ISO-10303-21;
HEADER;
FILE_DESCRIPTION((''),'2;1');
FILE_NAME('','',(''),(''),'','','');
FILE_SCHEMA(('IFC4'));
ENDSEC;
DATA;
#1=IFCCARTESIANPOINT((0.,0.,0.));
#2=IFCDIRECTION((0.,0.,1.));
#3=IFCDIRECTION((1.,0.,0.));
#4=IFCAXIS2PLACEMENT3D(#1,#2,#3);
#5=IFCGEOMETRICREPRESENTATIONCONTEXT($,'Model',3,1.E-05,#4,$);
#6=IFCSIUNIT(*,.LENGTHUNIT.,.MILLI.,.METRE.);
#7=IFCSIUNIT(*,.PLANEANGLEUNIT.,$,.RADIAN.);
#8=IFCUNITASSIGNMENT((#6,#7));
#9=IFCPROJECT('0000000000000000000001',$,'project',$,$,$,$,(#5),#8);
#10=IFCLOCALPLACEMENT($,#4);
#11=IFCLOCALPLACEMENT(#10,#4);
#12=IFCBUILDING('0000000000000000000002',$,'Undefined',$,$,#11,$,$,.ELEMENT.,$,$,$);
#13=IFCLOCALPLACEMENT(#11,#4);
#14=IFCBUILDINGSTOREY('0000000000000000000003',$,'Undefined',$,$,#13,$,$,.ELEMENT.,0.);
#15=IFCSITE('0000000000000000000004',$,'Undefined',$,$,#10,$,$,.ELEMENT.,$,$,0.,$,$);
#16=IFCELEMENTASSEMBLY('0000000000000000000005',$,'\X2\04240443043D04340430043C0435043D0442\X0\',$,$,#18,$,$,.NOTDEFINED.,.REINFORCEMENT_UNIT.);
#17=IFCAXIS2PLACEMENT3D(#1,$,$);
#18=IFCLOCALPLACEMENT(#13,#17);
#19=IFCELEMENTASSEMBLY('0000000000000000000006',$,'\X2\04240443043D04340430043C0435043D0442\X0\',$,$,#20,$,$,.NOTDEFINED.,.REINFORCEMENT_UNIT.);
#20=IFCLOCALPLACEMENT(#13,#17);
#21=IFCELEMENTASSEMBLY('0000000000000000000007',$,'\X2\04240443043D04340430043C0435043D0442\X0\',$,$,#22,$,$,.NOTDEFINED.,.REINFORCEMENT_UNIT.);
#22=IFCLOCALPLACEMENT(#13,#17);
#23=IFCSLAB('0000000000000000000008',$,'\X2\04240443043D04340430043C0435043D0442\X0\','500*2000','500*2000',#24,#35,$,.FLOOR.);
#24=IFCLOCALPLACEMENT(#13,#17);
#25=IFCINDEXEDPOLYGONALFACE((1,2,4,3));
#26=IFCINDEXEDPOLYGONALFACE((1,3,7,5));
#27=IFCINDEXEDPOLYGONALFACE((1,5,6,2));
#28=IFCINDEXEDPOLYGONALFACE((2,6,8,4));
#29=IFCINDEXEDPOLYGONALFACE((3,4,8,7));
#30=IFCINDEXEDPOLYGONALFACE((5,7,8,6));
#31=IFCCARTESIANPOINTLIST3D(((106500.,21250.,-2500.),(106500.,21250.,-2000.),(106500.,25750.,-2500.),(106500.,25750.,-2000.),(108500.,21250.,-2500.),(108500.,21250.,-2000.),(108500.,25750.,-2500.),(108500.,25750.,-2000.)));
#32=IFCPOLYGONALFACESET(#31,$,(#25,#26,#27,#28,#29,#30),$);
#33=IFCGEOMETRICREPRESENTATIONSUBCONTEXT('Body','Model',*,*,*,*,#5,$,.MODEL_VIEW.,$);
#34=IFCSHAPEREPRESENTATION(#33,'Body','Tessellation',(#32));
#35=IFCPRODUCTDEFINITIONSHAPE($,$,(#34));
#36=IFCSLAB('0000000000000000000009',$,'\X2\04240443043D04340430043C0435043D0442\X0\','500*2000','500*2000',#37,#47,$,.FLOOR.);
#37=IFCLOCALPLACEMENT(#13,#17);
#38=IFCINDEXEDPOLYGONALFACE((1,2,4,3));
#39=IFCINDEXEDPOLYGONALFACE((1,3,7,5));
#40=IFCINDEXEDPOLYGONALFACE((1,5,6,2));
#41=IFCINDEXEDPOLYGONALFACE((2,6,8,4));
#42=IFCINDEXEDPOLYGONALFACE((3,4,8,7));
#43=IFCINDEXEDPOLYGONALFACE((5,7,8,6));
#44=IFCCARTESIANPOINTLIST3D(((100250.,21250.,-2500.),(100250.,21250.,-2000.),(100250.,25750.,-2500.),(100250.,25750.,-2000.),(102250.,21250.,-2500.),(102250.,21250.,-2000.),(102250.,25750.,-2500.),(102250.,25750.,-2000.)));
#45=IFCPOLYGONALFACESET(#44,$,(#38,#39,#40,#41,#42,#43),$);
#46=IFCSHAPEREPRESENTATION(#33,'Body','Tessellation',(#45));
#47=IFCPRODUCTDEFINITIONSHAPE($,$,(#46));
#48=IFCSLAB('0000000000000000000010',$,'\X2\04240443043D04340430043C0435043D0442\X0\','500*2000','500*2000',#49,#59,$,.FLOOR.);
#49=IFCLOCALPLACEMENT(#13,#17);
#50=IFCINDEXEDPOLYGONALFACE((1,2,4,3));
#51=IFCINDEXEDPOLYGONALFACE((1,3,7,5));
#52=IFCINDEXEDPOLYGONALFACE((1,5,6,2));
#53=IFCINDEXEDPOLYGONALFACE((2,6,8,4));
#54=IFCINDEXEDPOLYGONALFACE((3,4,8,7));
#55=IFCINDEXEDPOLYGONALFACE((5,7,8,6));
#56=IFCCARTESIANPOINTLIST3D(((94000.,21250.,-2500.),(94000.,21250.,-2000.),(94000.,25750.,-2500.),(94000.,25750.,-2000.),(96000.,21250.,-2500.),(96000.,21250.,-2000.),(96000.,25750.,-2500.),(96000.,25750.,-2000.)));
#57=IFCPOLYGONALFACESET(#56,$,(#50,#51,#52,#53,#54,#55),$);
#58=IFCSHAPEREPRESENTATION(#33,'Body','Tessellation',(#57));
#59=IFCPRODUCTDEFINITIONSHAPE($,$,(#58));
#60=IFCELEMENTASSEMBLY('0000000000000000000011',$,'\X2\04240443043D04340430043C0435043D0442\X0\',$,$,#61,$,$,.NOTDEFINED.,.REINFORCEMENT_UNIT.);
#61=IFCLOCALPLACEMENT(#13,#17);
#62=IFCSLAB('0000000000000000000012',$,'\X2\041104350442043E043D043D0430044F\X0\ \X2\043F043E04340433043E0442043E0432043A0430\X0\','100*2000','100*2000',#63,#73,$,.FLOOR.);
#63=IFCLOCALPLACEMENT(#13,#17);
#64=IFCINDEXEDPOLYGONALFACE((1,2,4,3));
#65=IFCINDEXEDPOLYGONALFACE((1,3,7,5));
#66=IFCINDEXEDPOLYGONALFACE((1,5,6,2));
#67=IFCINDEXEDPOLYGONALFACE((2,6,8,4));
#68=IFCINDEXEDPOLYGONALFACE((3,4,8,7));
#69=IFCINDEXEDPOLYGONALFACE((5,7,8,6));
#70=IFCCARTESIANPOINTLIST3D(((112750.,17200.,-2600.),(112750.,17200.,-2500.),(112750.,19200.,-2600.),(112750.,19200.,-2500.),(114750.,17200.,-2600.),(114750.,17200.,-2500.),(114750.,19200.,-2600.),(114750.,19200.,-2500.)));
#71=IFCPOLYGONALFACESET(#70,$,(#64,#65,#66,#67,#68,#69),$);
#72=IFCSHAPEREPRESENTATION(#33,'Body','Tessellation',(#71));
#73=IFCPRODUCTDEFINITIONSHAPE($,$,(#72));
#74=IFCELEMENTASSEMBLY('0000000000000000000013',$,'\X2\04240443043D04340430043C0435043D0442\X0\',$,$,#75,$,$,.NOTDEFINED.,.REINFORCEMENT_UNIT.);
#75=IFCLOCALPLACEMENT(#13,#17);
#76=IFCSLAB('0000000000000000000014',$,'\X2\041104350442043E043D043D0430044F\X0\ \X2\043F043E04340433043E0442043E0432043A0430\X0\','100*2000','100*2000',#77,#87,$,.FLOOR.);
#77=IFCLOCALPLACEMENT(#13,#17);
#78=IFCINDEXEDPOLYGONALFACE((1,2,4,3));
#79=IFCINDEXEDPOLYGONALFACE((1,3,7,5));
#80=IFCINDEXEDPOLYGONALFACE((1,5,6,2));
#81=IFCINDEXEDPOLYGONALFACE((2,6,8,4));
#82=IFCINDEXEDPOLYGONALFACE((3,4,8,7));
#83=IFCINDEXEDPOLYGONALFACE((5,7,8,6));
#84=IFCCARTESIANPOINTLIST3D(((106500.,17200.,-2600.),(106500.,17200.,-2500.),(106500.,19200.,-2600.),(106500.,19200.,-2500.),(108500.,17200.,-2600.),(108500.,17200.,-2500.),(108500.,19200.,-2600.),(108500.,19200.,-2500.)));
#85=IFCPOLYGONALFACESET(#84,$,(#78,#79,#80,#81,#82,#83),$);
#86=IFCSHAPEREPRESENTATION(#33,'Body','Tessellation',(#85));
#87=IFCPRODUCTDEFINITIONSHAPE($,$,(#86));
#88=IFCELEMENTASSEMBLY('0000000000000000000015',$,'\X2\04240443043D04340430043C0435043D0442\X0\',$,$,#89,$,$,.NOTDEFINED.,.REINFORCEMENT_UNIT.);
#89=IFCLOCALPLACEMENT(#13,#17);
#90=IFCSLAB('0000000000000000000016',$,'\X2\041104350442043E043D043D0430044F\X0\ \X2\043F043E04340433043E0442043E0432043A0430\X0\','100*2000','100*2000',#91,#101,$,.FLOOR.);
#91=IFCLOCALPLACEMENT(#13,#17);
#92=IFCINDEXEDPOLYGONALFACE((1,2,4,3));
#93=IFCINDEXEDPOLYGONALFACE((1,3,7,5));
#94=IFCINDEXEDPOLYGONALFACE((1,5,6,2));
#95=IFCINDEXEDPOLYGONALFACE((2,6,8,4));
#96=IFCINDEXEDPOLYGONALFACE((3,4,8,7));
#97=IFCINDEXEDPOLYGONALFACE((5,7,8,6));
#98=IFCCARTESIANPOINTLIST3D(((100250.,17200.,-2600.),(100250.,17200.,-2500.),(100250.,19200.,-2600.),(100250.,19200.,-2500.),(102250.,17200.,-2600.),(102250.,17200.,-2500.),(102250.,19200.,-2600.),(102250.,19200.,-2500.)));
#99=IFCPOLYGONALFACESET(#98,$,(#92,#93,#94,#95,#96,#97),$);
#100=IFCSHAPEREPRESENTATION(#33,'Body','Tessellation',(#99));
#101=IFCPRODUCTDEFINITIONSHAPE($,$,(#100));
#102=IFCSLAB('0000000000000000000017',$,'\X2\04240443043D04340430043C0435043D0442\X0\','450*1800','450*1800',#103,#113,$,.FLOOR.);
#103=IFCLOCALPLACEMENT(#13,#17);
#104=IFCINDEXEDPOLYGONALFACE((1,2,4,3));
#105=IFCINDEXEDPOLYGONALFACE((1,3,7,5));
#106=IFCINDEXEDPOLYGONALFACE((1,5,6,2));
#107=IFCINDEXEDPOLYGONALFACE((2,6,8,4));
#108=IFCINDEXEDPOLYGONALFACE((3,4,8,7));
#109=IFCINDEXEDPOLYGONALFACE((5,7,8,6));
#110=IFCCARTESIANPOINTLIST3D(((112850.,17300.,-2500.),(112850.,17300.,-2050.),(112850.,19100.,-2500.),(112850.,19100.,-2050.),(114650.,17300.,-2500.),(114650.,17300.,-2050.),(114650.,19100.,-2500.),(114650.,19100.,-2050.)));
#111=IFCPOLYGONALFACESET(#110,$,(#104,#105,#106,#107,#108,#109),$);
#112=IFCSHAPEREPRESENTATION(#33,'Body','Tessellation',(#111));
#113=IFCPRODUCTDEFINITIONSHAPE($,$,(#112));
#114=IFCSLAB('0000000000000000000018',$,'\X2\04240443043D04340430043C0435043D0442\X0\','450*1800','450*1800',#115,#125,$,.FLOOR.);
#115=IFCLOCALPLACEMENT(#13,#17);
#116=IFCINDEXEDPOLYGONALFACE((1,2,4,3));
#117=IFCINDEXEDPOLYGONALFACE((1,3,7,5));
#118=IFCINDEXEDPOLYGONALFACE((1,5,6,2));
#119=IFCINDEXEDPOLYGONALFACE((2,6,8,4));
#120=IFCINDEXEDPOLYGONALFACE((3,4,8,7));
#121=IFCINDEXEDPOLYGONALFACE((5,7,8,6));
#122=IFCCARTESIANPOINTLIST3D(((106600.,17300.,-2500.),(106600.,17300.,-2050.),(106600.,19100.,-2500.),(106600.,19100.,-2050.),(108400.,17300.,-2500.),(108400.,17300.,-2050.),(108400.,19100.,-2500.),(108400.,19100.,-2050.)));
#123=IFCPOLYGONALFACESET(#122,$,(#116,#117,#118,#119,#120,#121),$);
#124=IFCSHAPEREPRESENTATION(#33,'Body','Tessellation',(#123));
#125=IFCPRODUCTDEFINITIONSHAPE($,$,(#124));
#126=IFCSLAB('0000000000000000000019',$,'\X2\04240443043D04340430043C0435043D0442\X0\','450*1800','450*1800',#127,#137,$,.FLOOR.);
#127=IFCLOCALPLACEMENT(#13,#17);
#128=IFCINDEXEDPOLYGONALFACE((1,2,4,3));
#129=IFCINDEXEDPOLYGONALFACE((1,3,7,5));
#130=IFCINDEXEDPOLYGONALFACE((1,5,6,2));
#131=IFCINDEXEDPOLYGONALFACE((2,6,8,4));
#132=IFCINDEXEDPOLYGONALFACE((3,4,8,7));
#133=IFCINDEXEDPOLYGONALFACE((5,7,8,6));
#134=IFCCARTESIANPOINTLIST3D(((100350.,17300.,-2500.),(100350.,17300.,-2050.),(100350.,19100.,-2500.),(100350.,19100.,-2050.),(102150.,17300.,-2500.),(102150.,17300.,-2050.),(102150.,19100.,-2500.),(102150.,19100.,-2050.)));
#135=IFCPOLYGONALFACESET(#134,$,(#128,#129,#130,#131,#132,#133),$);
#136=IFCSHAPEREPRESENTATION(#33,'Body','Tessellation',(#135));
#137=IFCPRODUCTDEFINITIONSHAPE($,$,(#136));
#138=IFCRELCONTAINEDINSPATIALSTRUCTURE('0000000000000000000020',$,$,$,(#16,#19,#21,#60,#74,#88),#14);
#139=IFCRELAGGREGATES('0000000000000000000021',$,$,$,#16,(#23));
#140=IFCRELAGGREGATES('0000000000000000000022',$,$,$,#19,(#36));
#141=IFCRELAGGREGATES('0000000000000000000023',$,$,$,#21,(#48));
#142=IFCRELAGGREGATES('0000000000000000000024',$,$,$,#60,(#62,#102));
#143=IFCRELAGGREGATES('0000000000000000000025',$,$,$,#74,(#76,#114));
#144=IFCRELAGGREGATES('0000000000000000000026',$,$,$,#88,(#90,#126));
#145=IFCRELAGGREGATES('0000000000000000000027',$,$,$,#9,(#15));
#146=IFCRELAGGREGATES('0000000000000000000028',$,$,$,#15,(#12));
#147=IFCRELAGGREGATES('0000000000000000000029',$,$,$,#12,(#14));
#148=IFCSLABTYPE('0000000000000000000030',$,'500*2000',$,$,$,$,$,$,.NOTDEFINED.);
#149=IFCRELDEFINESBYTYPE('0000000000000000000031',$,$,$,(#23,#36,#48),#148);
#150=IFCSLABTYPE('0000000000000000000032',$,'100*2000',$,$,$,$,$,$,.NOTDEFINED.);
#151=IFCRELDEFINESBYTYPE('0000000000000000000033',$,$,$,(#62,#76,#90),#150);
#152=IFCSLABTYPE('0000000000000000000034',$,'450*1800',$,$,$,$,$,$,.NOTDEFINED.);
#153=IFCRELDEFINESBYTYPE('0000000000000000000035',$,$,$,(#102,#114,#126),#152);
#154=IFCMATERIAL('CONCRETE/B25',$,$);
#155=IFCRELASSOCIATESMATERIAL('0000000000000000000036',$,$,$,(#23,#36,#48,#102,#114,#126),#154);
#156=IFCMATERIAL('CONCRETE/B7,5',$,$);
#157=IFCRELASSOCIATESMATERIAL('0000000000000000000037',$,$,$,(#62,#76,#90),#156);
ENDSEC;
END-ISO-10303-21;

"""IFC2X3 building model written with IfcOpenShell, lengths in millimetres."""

from ifc_helpers import new_model, si_unit, frame, origin_with_axes, place, context, subcontext, project, spatial, polyline, outline, extrude, material, type_object, element, aggregate, save


model = new_model("IFC2X3")

# Units and contexts
model_context = context("Model", 3, precision=1e-05, world=origin_with_axes())
body_context = subcontext(model_context, "Body", "Model", "MODEL_VIEW")
ifc_project = project(units=[si_unit("LENGTHUNIT", "METRE", prefix="MILLI"), si_unit("PLANEANGLEUNIT", "RADIAN")], contexts=[model_context])

# Site, building, storey
site_placement = place(None, origin_with_axes())
site = spatial("IfcSite", under=ifc_project, at=site_placement, Name="Undefined", CompositionType="ELEMENT", RefElevation=0.0)
building_placement = place(site_placement, origin_with_axes())
building = spatial("IfcBuilding", under=site, at=building_placement, Name="Undefined", CompositionType="ELEMENT")
storey_placement = place(building_placement, origin_with_axes())
storey = spatial("IfcBuildingStorey", under=building, at=storey_placement, Name="Undefined", CompositionType="ELEMENT", Elevation=0.0)

# Element assemblies
assembly_1_placement = place(storey_placement, origin_with_axes())
assembly_1 = element("IfcElementAssembly", 1, at=assembly_1_placement, inside=storey, Name="Фундамент", AssemblyPlace="NOTDEFINED", PredefinedType="REINFORCEMENT_UNIT")
ifc_material_1 = material(Name="CONCRETE/B25")
assembly_2_placement = place(storey_placement, origin_with_axes())
assembly_2 = element("IfcElementAssembly", 2, at=assembly_2_placement, inside=storey, Name="Фундамент", AssemblyPlace="NOTDEFINED", PredefinedType="REINFORCEMENT_UNIT")
assembly_3_placement = place(storey_placement, origin_with_axes())
assembly_3 = element("IfcElementAssembly", 3, at=assembly_3_placement, inside=storey, Name="Фундамент", AssemblyPlace="NOTDEFINED", PredefinedType="REINFORCEMENT_UNIT")

# Slabs
ifc_material_2 = material(Name="CONCRETE/B7,5")
slab_type_1 = type_object("IfcSlabType", Name="500*2000", PredefinedType="NOTDEFINED")
slab_1_placement = place(assembly_1_placement, frame((106500.0, 25750.0, -2250.0), z_axis=(0.0, 0.0, 1.0), x_axis=(0.0, -1.0, 0.0)))
slab_1 = element("IfcSlab", 4, at=slab_1_placement, type_object=slab_type_1, material=ifc_material_1, Name="Фундамент", Description="500*2000", ObjectType="500*2000", PredefinedType="FLOOR", context=body_context, shape_type="SweptSolid", body=[
    extrude(outline(polyline([(0.0, 0.0), (4500.0, 0.0), (4500.0, 2000.0), (0.0, 2000.0), (0.0, 0.0)])), frame((0.0, 0.0, -250.0), z_axis=(0.0, 0.0, 1.0), x_axis=(1.0, 0.0, 0.0)), (0.0, 0.0, 1.0), 500.0),
])
aggregate(assembly_1, [slab_1])
slab_2_placement = place(assembly_2_placement, frame((100250.0, 25750.0, -2250.0), z_axis=(0.0, 0.0, 1.0), x_axis=(0.0, -1.0, 0.0)))
slab_2 = element("IfcSlab", 5, at=slab_2_placement, type_object=slab_type_1, material=ifc_material_1, Name="Фундамент", Description="500*2000", ObjectType="500*2000", PredefinedType="FLOOR", context=body_context, shape_type="SweptSolid", body=[
    extrude(outline(polyline([(0.0, 0.0), (4500.0, 0.0), (4500.0, 2000.0), (0.0, 2000.0), (0.0, 0.0)])), frame((0.0, 0.0, -250.0), z_axis=(0.0, 0.0, 1.0), x_axis=(1.0, 0.0, 0.0)), (0.0, 0.0, 1.0), 500.0),
])
aggregate(assembly_2, [slab_2])
slab_3_placement = place(assembly_3_placement, frame((94000.0, 25750.0, -2250.0), z_axis=(0.0, 0.0, 1.0), x_axis=(0.0, -1.0, 0.0)))
slab_3 = element("IfcSlab", 6, at=slab_3_placement, type_object=slab_type_1, material=ifc_material_1, Name="Фундамент", Description="500*2000", ObjectType="500*2000", PredefinedType="FLOOR", context=body_context, shape_type="SweptSolid", body=[
    extrude(outline(polyline([(0.0, 0.0), (4500.0, 0.0), (4500.0, 2000.0), (0.0, 2000.0), (0.0, 0.0)])), frame((0.0, 0.0, -250.0), z_axis=(0.0, 0.0, 1.0), x_axis=(1.0, 0.0, 0.0)), (0.0, 0.0, 1.0), 500.0),
])
aggregate(assembly_3, [slab_3])

# Element assemblies, slabs
assembly_4_placement = place(storey_placement, origin_with_axes())
assembly_4 = element("IfcElementAssembly", 7, at=assembly_4_placement, inside=storey, Name="Фундамент", AssemblyPlace="NOTDEFINED", PredefinedType="REINFORCEMENT_UNIT")
slab_type_2 = type_object("IfcSlabType", Name="100*2000", PredefinedType="NOTDEFINED")
slab_4_placement = place(assembly_4_placement, frame((112750.0, 19200.0, -2550.0), z_axis=(0.0, 0.0, 1.0), x_axis=(0.0, -1.0, 0.0)))
slab_4 = element("IfcSlab", 8, at=slab_4_placement, type_object=slab_type_2, material=ifc_material_2, Name="Бетонная подготовка", Description="100*2000", ObjectType="100*2000", PredefinedType="FLOOR", context=body_context, shape_type="SweptSolid", body=[
    extrude(outline(polyline([(0.0, 0.0), (2000.0, 0.0), (2000.0, 2000.0), (0.0, 2000.0), (0.0, 0.0)])), frame((0.0, 0.0, -50.0), z_axis=(0.0, 0.0, 1.0), x_axis=(1.0, 0.0, 0.0)), (0.0, 0.0, 1.0), 100.0),
])
assembly_5_placement = place(storey_placement, origin_with_axes())
assembly_5 = element("IfcElementAssembly", 9, at=assembly_5_placement, inside=storey, Name="Фундамент", AssemblyPlace="NOTDEFINED", PredefinedType="REINFORCEMENT_UNIT")
slab_5_placement = place(assembly_5_placement, frame((106500.0, 19200.0, -2550.0), z_axis=(0.0, 0.0, 1.0), x_axis=(0.0, -1.0, 0.0)))
slab_5 = element("IfcSlab", 10, at=slab_5_placement, type_object=slab_type_2, material=ifc_material_2, Name="Бетонная подготовка", Description="100*2000", ObjectType="100*2000", PredefinedType="FLOOR", context=body_context, shape_type="SweptSolid", body=[
    extrude(outline(polyline([(0.0, 0.0), (2000.0, 0.0), (2000.0, 2000.0), (0.0, 2000.0), (0.0, 0.0)])), frame((0.0, 0.0, -50.0), z_axis=(0.0, 0.0, 1.0), x_axis=(1.0, 0.0, 0.0)), (0.0, 0.0, 1.0), 100.0),
])
assembly_6_placement = place(storey_placement, origin_with_axes())
assembly_6 = element("IfcElementAssembly", 11, at=assembly_6_placement, inside=storey, Name="Фундамент", AssemblyPlace="NOTDEFINED", PredefinedType="REINFORCEMENT_UNIT")
slab_6_placement = place(assembly_6_placement, frame((100250.0, 19200.0, -2550.0), z_axis=(0.0, 0.0, 1.0), x_axis=(0.0, -1.0, 0.0)))
slab_6 = element("IfcSlab", 12, at=slab_6_placement, type_object=slab_type_2, material=ifc_material_2, Name="Бетонная подготовка", Description="100*2000", ObjectType="100*2000", PredefinedType="FLOOR", context=body_context, shape_type="SweptSolid", body=[
    extrude(outline(polyline([(0.0, 0.0), (2000.0, 0.0), (2000.0, 2000.0), (0.0, 2000.0), (0.0, 0.0)])), frame((0.0, 0.0, -50.0), z_axis=(0.0, 0.0, 1.0), x_axis=(1.0, 0.0, 0.0)), (0.0, 0.0, 1.0), 100.0),
])

# Slabs
slab_type_3 = type_object("IfcSlabType", Name="450*1800", PredefinedType="NOTDEFINED")
slab_7_placement = place(assembly_4_placement, frame((112850.0, 19100.0, -2275.0), z_axis=(0.0, 0.0, 1.0), x_axis=(0.0, -1.0, 0.0)))
slab_7 = element("IfcSlab", 13, at=slab_7_placement, type_object=slab_type_3, material=ifc_material_1, Name="Фундамент", Description="450*1800", ObjectType="450*1800", PredefinedType="FLOOR", context=body_context, shape_type="SweptSolid", body=[
    extrude(outline(polyline([(0.0, 0.0), (1800.0, 0.0), (1800.0, 1800.0), (0.0, 1800.0), (0.0, 0.0)])), frame((0.0, 0.0, -225.0), z_axis=(0.0, 0.0, 1.0), x_axis=(1.0, 0.0, 0.0)), (0.0, 0.0, 1.0), 450.0),
])
aggregate(assembly_4, [slab_4, slab_7])
slab_8_placement = place(assembly_5_placement, frame((106600.0, 19100.0, -2275.0), z_axis=(0.0, 0.0, 1.0), x_axis=(0.0, -1.0, 0.0)))
slab_8 = element("IfcSlab", 14, at=slab_8_placement, type_object=slab_type_3, material=ifc_material_1, Name="Фундамент", Description="450*1800", ObjectType="450*1800", PredefinedType="FLOOR", context=body_context, shape_type="SweptSolid", body=[
    extrude(outline(polyline([(0.0, 0.0), (1800.0, 0.0), (1800.0, 1800.0), (0.0, 1800.0), (0.0, 0.0)])), frame((0.0, 0.0, -225.0), z_axis=(0.0, 0.0, 1.0), x_axis=(1.0, 0.0, 0.0)), (0.0, 0.0, 1.0), 450.0),
])
aggregate(assembly_5, [slab_5, slab_8])
slab_9_placement = place(assembly_6_placement, frame((100350.0, 19100.0, -2275.0), z_axis=(0.0, 0.0, 1.0), x_axis=(0.0, -1.0, 0.0)))
slab_9 = element("IfcSlab", 15, at=slab_9_placement, type_object=slab_type_3, material=ifc_material_1, Name="Фундамент", Description="450*1800", ObjectType="450*1800", PredefinedType="FLOOR", context=body_context, shape_type="SweptSolid", body=[
    extrude(outline(polyline([(0.0, 0.0), (1800.0, 0.0), (1800.0, 1800.0), (0.0, 1800.0), (0.0, 0.0)])), frame((0.0, 0.0, -225.0), z_axis=(0.0, 0.0, 1.0), x_axis=(1.0, 0.0, 0.0)), (0.0, 0.0, 1.0), 450.0),
])
aggregate(assembly_6, [slab_6, slab_9])

save(model, "model.ifc")
